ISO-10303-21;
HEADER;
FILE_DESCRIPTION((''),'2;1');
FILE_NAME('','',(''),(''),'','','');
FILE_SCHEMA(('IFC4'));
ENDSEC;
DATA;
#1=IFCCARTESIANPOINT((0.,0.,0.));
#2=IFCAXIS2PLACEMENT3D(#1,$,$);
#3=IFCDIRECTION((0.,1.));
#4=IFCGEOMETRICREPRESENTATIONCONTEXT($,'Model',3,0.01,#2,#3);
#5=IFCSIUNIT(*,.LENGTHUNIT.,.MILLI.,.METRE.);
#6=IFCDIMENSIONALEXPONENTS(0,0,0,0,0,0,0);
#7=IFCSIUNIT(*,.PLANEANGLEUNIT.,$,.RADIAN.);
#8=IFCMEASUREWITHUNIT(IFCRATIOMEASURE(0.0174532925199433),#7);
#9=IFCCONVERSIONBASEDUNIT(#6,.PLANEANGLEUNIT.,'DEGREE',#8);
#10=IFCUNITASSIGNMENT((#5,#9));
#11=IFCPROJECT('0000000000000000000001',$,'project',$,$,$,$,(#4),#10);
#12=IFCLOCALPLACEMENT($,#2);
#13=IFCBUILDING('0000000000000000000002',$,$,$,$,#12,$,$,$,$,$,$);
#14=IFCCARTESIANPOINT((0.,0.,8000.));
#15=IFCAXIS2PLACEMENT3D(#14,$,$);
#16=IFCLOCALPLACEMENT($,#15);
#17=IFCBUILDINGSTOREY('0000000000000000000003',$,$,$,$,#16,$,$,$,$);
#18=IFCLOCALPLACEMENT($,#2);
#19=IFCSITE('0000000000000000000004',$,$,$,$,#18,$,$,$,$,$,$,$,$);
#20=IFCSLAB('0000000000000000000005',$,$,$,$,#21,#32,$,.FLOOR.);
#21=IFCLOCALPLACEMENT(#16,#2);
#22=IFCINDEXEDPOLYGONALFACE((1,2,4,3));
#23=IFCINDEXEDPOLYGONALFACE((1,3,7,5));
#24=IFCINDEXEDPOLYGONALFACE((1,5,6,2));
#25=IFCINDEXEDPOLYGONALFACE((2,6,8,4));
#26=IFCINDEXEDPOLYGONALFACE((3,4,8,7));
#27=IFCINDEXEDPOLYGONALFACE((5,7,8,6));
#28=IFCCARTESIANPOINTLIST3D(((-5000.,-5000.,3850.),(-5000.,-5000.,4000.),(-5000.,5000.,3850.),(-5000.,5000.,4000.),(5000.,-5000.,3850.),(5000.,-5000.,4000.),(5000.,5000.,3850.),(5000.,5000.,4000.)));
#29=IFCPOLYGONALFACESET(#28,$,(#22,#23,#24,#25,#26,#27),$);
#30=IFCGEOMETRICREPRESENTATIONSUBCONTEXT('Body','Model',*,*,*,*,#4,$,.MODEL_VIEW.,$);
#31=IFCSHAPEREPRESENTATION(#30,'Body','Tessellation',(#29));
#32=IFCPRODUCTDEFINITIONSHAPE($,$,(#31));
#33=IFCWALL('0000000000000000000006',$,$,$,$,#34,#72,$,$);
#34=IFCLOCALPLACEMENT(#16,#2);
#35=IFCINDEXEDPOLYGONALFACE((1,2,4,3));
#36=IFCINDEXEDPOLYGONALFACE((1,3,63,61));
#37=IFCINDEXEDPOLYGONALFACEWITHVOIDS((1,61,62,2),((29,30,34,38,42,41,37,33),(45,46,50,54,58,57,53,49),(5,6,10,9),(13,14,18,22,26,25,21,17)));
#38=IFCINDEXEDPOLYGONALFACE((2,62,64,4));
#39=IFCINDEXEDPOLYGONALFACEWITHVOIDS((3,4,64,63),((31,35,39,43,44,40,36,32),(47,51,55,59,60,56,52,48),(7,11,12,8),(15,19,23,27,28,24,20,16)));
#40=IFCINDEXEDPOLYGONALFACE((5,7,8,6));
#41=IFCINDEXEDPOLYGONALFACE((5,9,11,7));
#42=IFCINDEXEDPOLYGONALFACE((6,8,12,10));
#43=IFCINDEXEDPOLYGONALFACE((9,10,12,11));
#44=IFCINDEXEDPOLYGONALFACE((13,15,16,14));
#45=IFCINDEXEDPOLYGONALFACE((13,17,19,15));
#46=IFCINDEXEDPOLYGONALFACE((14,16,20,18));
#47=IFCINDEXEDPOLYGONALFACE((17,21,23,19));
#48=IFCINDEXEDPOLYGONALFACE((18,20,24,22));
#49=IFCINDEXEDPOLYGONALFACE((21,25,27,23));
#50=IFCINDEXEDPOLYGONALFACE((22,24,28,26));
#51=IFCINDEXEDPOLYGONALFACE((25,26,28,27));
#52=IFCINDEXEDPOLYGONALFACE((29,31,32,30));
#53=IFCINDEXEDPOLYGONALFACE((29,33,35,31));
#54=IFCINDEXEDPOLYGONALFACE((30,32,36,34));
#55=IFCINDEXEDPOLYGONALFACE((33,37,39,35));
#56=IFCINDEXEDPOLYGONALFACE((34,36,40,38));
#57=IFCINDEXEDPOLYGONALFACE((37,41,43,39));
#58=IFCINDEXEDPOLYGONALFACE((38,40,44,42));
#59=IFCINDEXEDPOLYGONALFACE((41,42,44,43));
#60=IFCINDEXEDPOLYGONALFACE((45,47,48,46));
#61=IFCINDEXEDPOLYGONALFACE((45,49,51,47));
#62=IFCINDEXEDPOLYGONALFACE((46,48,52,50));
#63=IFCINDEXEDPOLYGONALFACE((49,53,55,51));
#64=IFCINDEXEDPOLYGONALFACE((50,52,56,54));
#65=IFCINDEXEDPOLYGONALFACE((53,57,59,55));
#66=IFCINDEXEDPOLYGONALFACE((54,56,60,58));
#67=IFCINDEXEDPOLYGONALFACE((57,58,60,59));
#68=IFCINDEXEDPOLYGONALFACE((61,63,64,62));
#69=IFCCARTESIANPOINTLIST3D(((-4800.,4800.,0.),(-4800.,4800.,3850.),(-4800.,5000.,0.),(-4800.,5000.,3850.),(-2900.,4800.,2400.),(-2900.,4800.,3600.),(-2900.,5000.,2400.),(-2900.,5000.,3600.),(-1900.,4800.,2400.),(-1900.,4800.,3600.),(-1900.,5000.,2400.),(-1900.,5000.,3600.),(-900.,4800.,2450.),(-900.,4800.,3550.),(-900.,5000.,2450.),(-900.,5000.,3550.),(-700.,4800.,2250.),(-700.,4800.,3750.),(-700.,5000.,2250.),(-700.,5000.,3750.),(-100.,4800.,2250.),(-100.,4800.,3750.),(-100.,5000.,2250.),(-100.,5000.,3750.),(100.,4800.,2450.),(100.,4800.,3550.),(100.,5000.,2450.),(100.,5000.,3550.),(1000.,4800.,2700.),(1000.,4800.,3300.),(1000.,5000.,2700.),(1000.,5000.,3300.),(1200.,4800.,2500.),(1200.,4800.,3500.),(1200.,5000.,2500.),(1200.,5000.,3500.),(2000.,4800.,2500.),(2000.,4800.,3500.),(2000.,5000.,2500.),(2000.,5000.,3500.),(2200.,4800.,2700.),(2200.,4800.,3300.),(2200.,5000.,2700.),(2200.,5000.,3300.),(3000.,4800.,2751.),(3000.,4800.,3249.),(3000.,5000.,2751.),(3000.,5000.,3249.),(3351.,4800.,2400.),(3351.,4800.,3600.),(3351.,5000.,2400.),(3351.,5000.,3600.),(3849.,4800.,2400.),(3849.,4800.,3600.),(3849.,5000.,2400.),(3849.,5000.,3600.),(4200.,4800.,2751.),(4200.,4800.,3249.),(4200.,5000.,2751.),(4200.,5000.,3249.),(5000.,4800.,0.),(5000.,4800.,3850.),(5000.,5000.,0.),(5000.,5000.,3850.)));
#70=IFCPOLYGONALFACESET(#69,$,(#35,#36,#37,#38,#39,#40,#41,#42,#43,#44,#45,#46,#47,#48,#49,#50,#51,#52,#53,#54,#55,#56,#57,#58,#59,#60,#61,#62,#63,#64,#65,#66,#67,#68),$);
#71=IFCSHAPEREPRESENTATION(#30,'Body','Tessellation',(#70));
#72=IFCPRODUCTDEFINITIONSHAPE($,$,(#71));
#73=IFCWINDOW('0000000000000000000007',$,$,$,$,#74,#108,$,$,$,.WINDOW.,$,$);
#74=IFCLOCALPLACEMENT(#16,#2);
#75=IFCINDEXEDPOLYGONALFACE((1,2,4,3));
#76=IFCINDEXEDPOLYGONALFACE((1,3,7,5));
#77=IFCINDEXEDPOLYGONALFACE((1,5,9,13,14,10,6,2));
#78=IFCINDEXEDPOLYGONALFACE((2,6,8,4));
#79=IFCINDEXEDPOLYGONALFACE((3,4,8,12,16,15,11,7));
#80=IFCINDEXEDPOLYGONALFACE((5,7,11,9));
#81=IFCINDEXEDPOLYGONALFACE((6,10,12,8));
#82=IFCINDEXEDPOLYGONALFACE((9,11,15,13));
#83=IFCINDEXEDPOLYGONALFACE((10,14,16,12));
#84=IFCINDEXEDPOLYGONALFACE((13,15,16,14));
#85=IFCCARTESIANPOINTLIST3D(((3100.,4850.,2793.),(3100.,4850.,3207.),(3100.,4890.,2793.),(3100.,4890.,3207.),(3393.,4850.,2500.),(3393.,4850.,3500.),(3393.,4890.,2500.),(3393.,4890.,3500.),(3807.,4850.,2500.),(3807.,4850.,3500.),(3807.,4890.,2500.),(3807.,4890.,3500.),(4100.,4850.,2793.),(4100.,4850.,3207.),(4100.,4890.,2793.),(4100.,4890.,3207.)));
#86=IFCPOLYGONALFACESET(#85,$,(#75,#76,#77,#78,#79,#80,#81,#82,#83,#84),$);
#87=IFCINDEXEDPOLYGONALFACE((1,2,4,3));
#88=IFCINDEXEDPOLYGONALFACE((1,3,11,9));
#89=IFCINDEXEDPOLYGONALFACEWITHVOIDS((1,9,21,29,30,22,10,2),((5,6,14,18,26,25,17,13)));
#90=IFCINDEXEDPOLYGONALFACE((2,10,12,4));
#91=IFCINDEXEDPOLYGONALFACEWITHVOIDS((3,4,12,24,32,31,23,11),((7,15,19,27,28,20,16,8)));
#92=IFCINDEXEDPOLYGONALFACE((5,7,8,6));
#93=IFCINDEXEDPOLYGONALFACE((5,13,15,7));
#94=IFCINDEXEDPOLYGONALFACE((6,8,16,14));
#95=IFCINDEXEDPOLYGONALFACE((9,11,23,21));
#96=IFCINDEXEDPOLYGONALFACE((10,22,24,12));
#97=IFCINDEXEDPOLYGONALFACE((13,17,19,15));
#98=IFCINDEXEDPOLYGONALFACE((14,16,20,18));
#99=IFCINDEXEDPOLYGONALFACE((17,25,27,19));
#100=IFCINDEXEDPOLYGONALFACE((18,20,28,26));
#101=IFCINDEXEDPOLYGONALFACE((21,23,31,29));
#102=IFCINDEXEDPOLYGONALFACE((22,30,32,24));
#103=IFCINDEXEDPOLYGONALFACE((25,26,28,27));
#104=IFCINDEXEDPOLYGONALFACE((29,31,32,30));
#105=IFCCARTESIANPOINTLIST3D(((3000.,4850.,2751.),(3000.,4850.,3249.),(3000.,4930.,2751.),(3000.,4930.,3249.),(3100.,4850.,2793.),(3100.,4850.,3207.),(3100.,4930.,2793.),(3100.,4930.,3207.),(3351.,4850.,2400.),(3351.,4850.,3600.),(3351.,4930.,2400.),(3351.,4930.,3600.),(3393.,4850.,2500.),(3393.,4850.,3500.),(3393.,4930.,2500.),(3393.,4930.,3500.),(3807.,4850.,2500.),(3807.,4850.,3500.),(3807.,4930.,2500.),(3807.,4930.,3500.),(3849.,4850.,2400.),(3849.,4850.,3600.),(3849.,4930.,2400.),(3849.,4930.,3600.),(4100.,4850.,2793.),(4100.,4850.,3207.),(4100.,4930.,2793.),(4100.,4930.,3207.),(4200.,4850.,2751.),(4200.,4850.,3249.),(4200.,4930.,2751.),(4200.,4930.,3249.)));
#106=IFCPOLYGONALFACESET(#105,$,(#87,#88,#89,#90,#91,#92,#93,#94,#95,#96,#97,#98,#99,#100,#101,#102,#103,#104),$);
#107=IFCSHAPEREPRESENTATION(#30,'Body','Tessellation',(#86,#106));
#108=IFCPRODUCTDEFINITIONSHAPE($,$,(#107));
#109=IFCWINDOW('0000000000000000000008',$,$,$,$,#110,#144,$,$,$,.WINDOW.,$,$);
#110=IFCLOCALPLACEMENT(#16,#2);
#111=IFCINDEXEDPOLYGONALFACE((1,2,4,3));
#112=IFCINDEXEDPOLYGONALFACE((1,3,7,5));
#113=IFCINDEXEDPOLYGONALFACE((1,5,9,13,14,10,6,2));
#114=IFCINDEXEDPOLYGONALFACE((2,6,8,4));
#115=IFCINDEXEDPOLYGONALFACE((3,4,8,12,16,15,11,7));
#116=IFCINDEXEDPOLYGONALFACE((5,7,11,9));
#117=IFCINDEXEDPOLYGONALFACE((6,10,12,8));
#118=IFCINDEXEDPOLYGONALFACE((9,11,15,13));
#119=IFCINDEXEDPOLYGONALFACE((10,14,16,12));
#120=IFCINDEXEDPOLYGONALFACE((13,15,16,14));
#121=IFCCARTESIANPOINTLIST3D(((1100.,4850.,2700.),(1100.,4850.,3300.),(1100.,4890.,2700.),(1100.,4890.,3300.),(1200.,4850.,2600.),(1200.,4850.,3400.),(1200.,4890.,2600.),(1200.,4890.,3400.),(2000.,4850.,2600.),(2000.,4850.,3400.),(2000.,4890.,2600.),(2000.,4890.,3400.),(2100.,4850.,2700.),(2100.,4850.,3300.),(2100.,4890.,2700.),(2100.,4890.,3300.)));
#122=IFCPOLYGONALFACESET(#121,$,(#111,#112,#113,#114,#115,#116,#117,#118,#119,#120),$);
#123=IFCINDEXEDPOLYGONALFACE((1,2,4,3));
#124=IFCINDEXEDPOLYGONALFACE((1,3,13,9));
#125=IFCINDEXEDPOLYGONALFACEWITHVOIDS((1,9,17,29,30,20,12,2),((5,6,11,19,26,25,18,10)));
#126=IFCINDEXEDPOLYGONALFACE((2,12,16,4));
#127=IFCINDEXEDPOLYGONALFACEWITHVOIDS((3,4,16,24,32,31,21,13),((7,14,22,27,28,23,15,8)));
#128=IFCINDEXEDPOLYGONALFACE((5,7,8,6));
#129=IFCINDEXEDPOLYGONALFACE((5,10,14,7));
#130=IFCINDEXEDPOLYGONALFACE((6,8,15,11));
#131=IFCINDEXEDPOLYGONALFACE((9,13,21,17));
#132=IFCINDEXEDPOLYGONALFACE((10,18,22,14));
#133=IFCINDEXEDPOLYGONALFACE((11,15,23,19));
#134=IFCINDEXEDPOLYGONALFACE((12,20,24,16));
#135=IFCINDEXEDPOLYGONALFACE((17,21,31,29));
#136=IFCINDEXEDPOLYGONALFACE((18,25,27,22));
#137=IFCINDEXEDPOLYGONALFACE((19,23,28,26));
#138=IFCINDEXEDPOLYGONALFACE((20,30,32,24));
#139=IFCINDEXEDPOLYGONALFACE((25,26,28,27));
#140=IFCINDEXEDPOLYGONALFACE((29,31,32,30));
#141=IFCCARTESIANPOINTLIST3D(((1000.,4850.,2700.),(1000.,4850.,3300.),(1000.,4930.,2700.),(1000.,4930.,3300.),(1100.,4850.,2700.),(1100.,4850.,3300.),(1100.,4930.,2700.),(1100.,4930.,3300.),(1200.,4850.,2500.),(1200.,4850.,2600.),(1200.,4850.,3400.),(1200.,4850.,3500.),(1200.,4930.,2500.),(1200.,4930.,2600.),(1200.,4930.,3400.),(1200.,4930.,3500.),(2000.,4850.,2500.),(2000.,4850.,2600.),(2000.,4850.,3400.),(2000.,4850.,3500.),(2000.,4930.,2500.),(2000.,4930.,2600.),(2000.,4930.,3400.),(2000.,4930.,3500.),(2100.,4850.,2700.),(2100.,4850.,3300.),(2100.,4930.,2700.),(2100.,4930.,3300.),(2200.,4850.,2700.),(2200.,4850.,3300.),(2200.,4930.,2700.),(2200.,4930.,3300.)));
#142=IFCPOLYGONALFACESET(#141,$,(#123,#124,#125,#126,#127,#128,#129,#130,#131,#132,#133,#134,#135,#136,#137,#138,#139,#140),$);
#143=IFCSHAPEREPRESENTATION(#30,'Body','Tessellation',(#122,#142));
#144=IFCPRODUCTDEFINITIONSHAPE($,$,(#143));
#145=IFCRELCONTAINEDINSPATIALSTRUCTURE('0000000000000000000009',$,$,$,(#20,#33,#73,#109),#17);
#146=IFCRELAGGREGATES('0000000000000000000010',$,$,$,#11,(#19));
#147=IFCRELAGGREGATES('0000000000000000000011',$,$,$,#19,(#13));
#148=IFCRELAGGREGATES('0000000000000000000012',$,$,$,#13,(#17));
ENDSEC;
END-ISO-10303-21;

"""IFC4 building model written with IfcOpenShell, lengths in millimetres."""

from ifc_helpers import new_model, entity, si_unit, converted_unit, direction, frame, origin, origin_2d, place, context, subcontext, project, spatial, polyline, rectangle, outline, extrude, element, save


model = new_model("IFC4")

# Units and contexts
model_context = context("Model", 3, precision=0.01, world=origin(), true_north=direction((0.0, 1.0)))
body_context = subcontext(model_context, "Body", "Model", "MODEL_VIEW")
ifc_project = project(units=[si_unit("LENGTHUNIT", "METRE", prefix="MILLI"), converted_unit("PLANEANGLEUNIT", "DEGREE", entity("IfcRatioMeasure", 0.0174532925199433), si_unit("PLANEANGLEUNIT", "RADIAN"), dimensions=[0, 0, 0, 0, 0, 0, 0])], contexts=[model_context])

# Site, building, storey
site_placement = place(None, origin())
site = spatial("IfcSite", under=ifc_project, at=site_placement)
building_placement = place(None, origin())
building = spatial("IfcBuilding", under=site, at=building_placement)
storey_placement = place(None, frame((0.0, 0.0, 8000.0)))
storey = spatial("IfcBuildingStorey", under=building, at=storey_placement)

# Slab
slab_placement = place(storey_placement, frame((0.0, 0.0, 3850.0)))
element("IfcSlab", 1, at=slab_placement, inside=storey, PredefinedType="FLOOR", context=body_context, shape_type="SweptSolid", body=[
    extrude(rectangle(XDim=10000.0, YDim=10000.0, at=origin_2d()), origin(), (0.0, 0.0, 1.0), 150.0),
])

# Wall, openings
wall_1_placement = place(storey_placement, frame((100.0, 4900.0, 0.0), z_axis=(0.0, 0.0, 1.0), x_axis=(-1.0, 0.0, 0.0)))
wall_1 = element("IfcWall", 2, at=wall_1_placement, inside=storey, context=body_context, shape_type="SweptSolid", body=[
    extrude(rectangle(XDim=9800.0, YDim=200.0, at=origin_2d()), origin(), (0.0, 0.0, 1.0), 3850.0),
])
window_1_placement = place(wall_1_placement, frame((-3500.0, 50.0, 3000.0)))
opening_1_placement = place(window_1_placement, frame((0.0, 50.0, 0.0)))
element("IfcOpeningElement", 3, at=opening_1_placement, cuts=wall_1, context=body_context, shape_type="SweptSolid", body=[
    extrude(outline(polyline([(-600.0, -249.0), (-600.0, 249.0), (-249.0, 600.0), (249.0, 600.0), (600.0, 249.0), (600.0, -249.0), (249.0, -600.0), (-249.0, -600.0), (-600.0, -249.0)])), frame((0.0, 0.0, 0.0), z_axis=(0.0, -1.0, 0.0), x_axis=(1.0, 0.0, 0.0)), (0.0, 0.0, 1.0), 200.0),
])
window_2_placement = place(wall_1_placement, frame((-1500.0, 50.0, 3000.0)))
opening_2_placement = place(window_2_placement, frame((0.0, 50.0, 0.0)))
element("IfcOpeningElement", 4, at=opening_2_placement, cuts=wall_1, context=body_context, shape_type="SweptSolid", body=[
    extrude(outline(polyline([(-600.0, -300.0), (-600.0, 300.0), (-400.0, 500.0), (400.0, 500.0), (600.0, 300.0), (600.0, -300.0), (400.0, -500.0), (-400.0, -500.0), (-600.0, -300.0)])), frame((0.0, 0.0, 0.0), z_axis=(0.0, -1.0, 0.0), x_axis=(1.0, 0.0, 0.0)), (0.0, 0.0, 1.0), 200.0),
])
window_3_placement = place(wall_1_placement, frame((500.0, 50.0, 3000.0)))
opening_3_placement = place(window_3_placement, frame((0.0, 50.0, 0.0)))
element("IfcOpeningElement", 5, at=opening_3_placement, cuts=wall_1, context=body_context, shape_type="SweptSolid", body=[
    extrude(outline(polyline([(-500.0, -550.0), (-500.0, 550.0), (-300.0, 750.0), (300.0, 750.0), (500.0, 550.0), (500.0, -550.0), (300.0, -750.0), (-300.0, -750.0), (-500.0, -550.0)])), frame((0.0, 0.0, 0.0), z_axis=(0.0, -1.0, 0.0), x_axis=(1.0, 0.0, 0.0)), (0.0, 0.0, 1.0), 200.0),
])
window_4_placement = place(wall_1_placement, frame((2500.0, 50.0, 3000.0)))
opening_4_placement = place(window_4_placement, frame((0.0, 50.0, 0.0)))
element("IfcOpeningElement", 6, at=opening_4_placement, cuts=wall_1, context=body_context, shape_type="SweptSolid", body=[
    extrude(outline(polyline([(-500.0, -600.0), (-500.0, 600.0), (-500.0, 600.0), (500.0, 600.0), (500.0, 600.0), (500.0, -600.0), (500.0, -600.0), (-500.0, -600.0), (-500.0, -600.0)])), frame((0.0, 0.0, 0.0), z_axis=(0.0, -1.0, 0.0), x_axis=(1.0, 0.0, 0.0)), (0.0, 0.0, 1.0), 200.0),
])

# Windows
cartesian_point_1 = entity("IfcCartesianPoint", [-500.0, -207.0])
shared_polyline_1 = entity("IfcPolyline", [cartesian_point_1, entity("IfcCartesianPoint", [-500.0, 207.0]), entity("IfcCartesianPoint", [-207.0, 500.0]), entity("IfcCartesianPoint", [207.0, 500.0]), entity("IfcCartesianPoint", [500.0, 207.0]), entity("IfcCartesianPoint", [500.0, -207.0]), entity("IfcCartesianPoint", [207.0, -500.0]), entity("IfcCartesianPoint", [-207.0, -500.0]), cartesian_point_1])
cartesian_point_2 = entity("IfcCartesianPoint", [-600.0, -249.0])
element("IfcWindow", 7, at=window_1_placement, inside=storey, PredefinedType="WINDOW", context=body_context, shape_type="SweptSolid", body=[
    entity("IfcExtrudedAreaSolid", entity("IfcArbitraryClosedProfileDef", "AREA", None, shared_polyline_1), entity("IfcAxis2Placement3D", entity("IfcCartesianPoint", [0.0, 0.0, 0.0]), entity("IfcDirection", [0.0, -1.0, 0.0]), entity("IfcDirection", [1.0, 0.0, 0.0])), entity("IfcDirection", [0.0, 0.0, 1.0]), 40.0),
    entity("IfcExtrudedAreaSolid", entity("IfcArbitraryProfileDefWithVoids", "AREA", None, entity("IfcPolyline", [cartesian_point_2, entity("IfcCartesianPoint", [-600.0, 249.0]), entity("IfcCartesianPoint", [-249.0, 600.0]), entity("IfcCartesianPoint", [249.0, 600.0]), entity("IfcCartesianPoint", [600.0, 249.0]), entity("IfcCartesianPoint", [600.0, -249.0]), entity("IfcCartesianPoint", [249.0, -600.0]), entity("IfcCartesianPoint", [-249.0, -600.0]), cartesian_point_2]), [shared_polyline_1]), entity("IfcAxis2Placement3D", entity("IfcCartesianPoint", [0.0, 0.0, 0.0]), entity("IfcDirection", [0.0, -1.0, 0.0]), entity("IfcDirection", [1.0, 0.0, 0.0])), entity("IfcDirection", [0.0, 0.0, 1.0]), 80.0),
])
cartesian_point_3 = entity("IfcCartesianPoint", [-500.0, -300.0])
shared_polyline_2 = entity("IfcPolyline", [cartesian_point_3, entity("IfcCartesianPoint", [-500.0, 300.0]), entity("IfcCartesianPoint", [-400.0, 400.0]), entity("IfcCartesianPoint", [400.0, 400.0]), entity("IfcCartesianPoint", [500.0, 300.0]), entity("IfcCartesianPoint", [500.0, -300.0]), entity("IfcCartesianPoint", [400.0, -400.0]), entity("IfcCartesianPoint", [-400.0, -400.0]), cartesian_point_3])
cartesian_point_4 = entity("IfcCartesianPoint", [-600.0, -300.0])
element("IfcWindow", 8, at=window_2_placement, inside=storey, PredefinedType="WINDOW", context=body_context, shape_type="SweptSolid", body=[
    entity("IfcExtrudedAreaSolid", entity("IfcArbitraryClosedProfileDef", "AREA", None, shared_polyline_2), entity("IfcAxis2Placement3D", entity("IfcCartesianPoint", [0.0, 0.0, 0.0]), entity("IfcDirection", [0.0, -1.0, 0.0]), entity("IfcDirection", [1.0, 0.0, 0.0])), entity("IfcDirection", [0.0, 0.0, 1.0]), 40.0),
    entity("IfcExtrudedAreaSolid", entity("IfcArbitraryProfileDefWithVoids", "AREA", None, entity("IfcPolyline", [cartesian_point_4, entity("IfcCartesianPoint", [-600.0, 300.0]), entity("IfcCartesianPoint", [-400.0, 500.0]), entity("IfcCartesianPoint", [400.0, 500.0]), entity("IfcCartesianPoint", [600.0, 300.0]), entity("IfcCartesianPoint", [600.0, -300.0]), entity("IfcCartesianPoint", [400.0, -500.0]), entity("IfcCartesianPoint", [-400.0, -500.0]), cartesian_point_4]), [shared_polyline_2]), entity("IfcAxis2Placement3D", entity("IfcCartesianPoint", [0.0, 0.0, 0.0]), entity("IfcDirection", [0.0, -1.0, 0.0]), entity("IfcDirection", [1.0, 0.0, 0.0])), entity("IfcDirection", [0.0, 0.0, 1.0]), 80.0),
])

save(model, "model.ifc")
